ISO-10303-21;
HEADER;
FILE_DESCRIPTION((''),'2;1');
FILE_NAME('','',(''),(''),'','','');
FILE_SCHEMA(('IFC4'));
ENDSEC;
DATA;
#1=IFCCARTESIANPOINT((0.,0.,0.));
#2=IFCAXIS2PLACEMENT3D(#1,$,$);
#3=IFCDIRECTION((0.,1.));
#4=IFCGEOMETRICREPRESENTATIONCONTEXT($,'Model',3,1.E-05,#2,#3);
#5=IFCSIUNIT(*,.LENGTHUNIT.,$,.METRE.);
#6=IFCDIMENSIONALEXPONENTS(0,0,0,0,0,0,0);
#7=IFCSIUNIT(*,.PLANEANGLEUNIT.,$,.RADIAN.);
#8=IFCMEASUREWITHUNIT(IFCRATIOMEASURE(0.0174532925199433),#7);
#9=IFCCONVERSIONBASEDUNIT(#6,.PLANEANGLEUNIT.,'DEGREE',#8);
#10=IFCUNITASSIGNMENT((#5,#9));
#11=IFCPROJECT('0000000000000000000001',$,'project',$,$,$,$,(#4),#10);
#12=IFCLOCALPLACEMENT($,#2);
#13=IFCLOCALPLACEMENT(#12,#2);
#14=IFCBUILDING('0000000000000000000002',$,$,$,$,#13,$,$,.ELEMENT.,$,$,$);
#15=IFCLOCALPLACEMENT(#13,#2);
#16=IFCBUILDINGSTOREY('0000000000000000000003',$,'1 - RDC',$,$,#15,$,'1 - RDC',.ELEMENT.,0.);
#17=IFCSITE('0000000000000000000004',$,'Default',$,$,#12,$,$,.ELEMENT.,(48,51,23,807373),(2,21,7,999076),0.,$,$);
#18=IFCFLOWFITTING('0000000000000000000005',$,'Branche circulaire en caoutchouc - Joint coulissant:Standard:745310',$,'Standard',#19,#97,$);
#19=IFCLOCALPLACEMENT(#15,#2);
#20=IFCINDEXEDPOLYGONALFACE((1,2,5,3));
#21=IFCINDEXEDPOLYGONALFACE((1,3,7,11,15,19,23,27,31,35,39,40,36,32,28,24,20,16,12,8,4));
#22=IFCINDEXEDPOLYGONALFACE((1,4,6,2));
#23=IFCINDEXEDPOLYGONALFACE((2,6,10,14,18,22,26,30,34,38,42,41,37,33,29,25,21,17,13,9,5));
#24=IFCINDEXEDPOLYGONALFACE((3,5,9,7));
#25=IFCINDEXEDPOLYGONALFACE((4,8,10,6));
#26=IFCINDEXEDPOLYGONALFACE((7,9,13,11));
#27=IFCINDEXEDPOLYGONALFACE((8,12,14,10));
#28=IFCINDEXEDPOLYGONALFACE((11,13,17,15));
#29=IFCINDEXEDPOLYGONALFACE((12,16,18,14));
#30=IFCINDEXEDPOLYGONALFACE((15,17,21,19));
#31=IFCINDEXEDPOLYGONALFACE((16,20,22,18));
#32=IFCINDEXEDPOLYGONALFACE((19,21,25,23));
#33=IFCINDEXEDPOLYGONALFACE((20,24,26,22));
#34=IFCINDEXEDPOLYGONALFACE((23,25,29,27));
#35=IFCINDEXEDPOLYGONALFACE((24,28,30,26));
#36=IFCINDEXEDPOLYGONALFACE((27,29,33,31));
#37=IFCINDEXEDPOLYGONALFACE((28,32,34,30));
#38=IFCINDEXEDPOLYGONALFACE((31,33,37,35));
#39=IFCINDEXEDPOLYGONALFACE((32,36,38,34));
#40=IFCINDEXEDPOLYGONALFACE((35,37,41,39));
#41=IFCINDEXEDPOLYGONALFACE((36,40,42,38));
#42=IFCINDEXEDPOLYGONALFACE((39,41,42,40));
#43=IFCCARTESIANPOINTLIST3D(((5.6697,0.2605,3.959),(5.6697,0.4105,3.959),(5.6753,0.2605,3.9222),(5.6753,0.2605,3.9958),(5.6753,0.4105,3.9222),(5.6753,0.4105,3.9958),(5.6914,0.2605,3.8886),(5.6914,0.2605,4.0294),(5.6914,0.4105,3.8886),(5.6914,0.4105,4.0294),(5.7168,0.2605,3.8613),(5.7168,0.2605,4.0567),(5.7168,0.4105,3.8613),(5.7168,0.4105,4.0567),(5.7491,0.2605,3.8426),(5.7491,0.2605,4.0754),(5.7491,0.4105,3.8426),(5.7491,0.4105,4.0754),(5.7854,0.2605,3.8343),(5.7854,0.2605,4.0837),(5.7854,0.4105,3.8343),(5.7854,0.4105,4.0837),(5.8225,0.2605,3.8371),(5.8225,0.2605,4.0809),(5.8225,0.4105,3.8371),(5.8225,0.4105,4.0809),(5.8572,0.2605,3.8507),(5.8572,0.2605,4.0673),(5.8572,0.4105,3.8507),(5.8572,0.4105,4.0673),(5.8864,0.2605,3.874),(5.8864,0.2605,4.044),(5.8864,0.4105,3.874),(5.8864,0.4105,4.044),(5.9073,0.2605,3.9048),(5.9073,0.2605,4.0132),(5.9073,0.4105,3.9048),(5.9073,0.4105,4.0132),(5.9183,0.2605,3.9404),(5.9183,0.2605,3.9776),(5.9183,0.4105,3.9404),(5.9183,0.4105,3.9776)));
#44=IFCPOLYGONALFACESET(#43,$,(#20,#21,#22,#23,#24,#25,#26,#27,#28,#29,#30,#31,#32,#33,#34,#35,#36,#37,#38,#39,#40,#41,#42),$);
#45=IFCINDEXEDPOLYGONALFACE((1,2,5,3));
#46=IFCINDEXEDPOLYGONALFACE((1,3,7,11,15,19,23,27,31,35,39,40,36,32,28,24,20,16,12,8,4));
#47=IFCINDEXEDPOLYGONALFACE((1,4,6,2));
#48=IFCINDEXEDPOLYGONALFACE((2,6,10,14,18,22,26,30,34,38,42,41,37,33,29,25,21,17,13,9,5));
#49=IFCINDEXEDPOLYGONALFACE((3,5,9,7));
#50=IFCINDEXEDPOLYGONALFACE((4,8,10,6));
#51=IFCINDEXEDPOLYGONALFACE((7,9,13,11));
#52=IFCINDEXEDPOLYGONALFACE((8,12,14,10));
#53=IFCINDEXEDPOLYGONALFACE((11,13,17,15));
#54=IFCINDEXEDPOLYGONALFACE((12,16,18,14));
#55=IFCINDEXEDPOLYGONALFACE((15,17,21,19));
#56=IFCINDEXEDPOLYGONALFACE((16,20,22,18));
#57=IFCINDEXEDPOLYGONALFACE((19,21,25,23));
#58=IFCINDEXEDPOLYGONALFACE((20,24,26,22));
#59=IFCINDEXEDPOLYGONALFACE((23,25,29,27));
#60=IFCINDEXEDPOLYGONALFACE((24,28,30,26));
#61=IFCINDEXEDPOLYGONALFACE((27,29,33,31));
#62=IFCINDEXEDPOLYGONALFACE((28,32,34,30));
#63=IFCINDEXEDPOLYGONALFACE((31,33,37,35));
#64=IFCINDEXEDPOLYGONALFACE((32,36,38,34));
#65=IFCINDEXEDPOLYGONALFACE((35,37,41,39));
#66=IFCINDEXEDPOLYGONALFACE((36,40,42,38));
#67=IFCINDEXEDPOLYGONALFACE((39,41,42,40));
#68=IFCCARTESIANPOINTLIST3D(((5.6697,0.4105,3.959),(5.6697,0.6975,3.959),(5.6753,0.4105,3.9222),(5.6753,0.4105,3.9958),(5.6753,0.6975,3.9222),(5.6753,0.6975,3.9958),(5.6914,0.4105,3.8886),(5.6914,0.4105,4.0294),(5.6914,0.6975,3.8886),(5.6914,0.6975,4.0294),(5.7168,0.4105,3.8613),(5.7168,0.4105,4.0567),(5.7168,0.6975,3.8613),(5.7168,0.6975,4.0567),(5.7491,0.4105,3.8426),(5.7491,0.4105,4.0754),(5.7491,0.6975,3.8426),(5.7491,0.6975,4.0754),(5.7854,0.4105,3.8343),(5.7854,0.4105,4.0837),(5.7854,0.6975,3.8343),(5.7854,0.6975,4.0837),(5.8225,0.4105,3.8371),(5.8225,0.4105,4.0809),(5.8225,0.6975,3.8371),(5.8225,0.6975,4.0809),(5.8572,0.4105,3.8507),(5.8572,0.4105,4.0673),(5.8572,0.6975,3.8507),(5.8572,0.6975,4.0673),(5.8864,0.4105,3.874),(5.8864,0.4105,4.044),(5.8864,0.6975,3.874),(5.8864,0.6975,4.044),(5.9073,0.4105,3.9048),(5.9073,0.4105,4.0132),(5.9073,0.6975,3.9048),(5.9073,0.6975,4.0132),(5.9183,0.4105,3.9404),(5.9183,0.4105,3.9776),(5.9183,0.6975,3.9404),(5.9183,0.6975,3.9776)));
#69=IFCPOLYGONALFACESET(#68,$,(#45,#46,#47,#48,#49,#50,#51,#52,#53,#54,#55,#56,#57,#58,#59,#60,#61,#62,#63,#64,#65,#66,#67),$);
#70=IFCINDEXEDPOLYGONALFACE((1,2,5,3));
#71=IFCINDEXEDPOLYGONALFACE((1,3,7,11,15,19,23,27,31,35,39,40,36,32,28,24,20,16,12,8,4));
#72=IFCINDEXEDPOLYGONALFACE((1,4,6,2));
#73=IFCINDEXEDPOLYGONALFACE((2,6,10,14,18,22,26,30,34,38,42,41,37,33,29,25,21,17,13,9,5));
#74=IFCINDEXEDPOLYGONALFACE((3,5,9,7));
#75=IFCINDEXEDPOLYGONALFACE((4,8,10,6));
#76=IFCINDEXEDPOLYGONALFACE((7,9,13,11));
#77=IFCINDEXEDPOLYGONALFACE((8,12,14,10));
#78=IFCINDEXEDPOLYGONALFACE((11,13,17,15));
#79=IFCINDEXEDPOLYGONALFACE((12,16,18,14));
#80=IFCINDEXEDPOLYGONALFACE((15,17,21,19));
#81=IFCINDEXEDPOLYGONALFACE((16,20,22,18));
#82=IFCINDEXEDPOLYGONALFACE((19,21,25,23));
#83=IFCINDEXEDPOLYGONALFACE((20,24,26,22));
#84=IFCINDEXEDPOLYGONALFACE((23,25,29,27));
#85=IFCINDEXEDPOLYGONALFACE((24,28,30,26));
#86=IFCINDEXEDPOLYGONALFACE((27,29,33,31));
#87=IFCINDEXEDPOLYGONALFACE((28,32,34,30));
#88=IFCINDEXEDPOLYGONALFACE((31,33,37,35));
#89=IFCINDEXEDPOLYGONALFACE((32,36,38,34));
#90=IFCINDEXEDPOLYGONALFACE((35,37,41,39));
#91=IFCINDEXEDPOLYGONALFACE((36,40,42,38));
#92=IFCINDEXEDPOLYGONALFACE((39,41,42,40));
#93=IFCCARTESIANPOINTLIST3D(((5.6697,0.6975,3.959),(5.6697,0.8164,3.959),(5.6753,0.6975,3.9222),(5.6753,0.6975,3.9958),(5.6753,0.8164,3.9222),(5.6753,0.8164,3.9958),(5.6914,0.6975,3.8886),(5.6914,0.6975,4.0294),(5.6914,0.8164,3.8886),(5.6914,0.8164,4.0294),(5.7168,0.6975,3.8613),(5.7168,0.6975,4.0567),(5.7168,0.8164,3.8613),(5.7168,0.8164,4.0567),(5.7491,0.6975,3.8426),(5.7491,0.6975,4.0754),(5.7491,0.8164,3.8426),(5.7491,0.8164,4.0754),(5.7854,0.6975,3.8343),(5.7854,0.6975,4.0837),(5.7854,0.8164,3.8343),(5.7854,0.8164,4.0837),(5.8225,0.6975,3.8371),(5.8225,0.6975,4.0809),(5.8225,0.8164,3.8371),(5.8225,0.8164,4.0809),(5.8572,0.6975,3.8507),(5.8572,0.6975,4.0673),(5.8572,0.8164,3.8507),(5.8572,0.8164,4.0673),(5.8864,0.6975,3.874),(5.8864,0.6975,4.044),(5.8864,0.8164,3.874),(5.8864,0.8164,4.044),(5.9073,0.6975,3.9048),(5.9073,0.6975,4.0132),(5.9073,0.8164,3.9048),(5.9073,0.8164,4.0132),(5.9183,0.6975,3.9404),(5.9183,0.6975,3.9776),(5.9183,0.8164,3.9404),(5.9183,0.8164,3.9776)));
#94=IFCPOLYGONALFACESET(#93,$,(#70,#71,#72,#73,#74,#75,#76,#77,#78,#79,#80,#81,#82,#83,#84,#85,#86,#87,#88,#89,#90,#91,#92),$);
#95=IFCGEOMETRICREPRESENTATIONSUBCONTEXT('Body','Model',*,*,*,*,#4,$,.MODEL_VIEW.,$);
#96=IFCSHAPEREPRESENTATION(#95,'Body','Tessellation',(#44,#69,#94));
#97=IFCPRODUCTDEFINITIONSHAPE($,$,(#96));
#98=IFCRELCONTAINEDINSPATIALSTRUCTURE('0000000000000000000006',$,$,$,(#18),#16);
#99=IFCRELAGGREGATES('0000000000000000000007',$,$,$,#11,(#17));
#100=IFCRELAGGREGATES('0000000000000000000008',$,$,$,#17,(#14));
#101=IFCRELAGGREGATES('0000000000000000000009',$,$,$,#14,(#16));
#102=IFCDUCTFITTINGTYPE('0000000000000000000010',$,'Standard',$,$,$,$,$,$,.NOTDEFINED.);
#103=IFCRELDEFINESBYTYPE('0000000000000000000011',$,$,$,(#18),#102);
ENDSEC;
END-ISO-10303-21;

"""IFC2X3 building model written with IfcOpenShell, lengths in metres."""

from ifc_helpers import new_model, entity, si_unit, converted_unit, direction, frame, frame_2d, origin, place, context, subcontext, project, spatial, circle, extrude, source, transform, mapped, type_object, type_shapes, element, save


model = new_model("IFC2X3")

# Units and contexts
model_context = context("Model", 3, precision=1e-05, world=origin(), true_north=direction((0.0, 1.0)))
body_context = subcontext(model_context, "Body", "Model", "MODEL_VIEW")
ifc_project = project(units=[si_unit("LENGTHUNIT", "METRE"), converted_unit("PLANEANGLEUNIT", "DEGREE", entity("IfcRatioMeasure", 0.0174532925199433), si_unit("PLANEANGLEUNIT", "RADIAN"), dimensions=[0, 0, 0, 0, 0, 0, 0])], contexts=[model_context])

# Site, building, storey
site_placement = place(None, origin())
site = spatial("IfcSite", under=ifc_project, at=site_placement, Name="Default", CompositionType="ELEMENT", RefLatitude=(48, 51, 23, 807373), RefLongitude=(2, 21, 7, 999076), RefElevation=0.0)
building_placement = place(site_placement, origin())
building = spatial("IfcBuilding", under=site, at=building_placement, CompositionType="ELEMENT")
storey_placement = place(building_placement, origin())
storey = spatial("IfcBuildingStorey", under=building, at=storey_placement, Name="1 - RDC", LongName="1 - RDC", CompositionType="ELEMENT", Elevation=0.0)

# Flow fitting
duct_fitting_type = type_object("IfcDuctFittingType", Name="Standard", PredefinedType="NOTDEFINED")
shared_shape = source(origin(), body_context, "Body", "SweptSolid", [
    extrude(circle(Radius=0.125, at=frame_2d((0.0, 0.0), x_axis=(1.0, 0.0))), frame((0.287, 0.0, 0.0), z_axis=(1.0, 0.0, 0.0), x_axis=(0.0, 1.0, 0.0)), (0.0, 0.0, 1.0), 0.15),
    extrude(circle(Radius=0.125, at=frame_2d((0.0, 0.0), x_axis=(1.0, 0.0))), frame((0.0, 0.0, 0.0), z_axis=(1.0, 0.0, 0.0), x_axis=(0.0, 1.0, 0.0)), (0.0, 0.0, 1.0), 0.287),
    extrude(circle(Radius=0.125, at=frame_2d((0.0, 0.0), x_axis=(1.0, 0.0))), frame((-0.1189, 0.0, 0.0), z_axis=(1.0, 0.0, 0.0), x_axis=(0.0, 1.0, 0.0)), (0.0, 0.0, 1.0), 0.1189),
])
type_shapes(duct_fitting_type, [shared_shape])
flow_fitting_placement = place(storey_placement, frame((5.7947, 0.6975, 3.959), z_axis=(0.0, 0.0, -1.0), x_axis=(0.0, -1.0, 0.0)))
element("IfcFlowFitting", 1, at=flow_fitting_placement, inside=storey, type_object=duct_fitting_type, Name="Branche circulaire en caoutchouc - Joint coulissant:Standard:745310", ObjectType="Standard", context=body_context, shape_type="MappedRepresentation", body=[
    mapped(shared_shape, transform((0.0, 0.0, 0.0), scale=1.0)),
])

save(model, "model.ifc")
